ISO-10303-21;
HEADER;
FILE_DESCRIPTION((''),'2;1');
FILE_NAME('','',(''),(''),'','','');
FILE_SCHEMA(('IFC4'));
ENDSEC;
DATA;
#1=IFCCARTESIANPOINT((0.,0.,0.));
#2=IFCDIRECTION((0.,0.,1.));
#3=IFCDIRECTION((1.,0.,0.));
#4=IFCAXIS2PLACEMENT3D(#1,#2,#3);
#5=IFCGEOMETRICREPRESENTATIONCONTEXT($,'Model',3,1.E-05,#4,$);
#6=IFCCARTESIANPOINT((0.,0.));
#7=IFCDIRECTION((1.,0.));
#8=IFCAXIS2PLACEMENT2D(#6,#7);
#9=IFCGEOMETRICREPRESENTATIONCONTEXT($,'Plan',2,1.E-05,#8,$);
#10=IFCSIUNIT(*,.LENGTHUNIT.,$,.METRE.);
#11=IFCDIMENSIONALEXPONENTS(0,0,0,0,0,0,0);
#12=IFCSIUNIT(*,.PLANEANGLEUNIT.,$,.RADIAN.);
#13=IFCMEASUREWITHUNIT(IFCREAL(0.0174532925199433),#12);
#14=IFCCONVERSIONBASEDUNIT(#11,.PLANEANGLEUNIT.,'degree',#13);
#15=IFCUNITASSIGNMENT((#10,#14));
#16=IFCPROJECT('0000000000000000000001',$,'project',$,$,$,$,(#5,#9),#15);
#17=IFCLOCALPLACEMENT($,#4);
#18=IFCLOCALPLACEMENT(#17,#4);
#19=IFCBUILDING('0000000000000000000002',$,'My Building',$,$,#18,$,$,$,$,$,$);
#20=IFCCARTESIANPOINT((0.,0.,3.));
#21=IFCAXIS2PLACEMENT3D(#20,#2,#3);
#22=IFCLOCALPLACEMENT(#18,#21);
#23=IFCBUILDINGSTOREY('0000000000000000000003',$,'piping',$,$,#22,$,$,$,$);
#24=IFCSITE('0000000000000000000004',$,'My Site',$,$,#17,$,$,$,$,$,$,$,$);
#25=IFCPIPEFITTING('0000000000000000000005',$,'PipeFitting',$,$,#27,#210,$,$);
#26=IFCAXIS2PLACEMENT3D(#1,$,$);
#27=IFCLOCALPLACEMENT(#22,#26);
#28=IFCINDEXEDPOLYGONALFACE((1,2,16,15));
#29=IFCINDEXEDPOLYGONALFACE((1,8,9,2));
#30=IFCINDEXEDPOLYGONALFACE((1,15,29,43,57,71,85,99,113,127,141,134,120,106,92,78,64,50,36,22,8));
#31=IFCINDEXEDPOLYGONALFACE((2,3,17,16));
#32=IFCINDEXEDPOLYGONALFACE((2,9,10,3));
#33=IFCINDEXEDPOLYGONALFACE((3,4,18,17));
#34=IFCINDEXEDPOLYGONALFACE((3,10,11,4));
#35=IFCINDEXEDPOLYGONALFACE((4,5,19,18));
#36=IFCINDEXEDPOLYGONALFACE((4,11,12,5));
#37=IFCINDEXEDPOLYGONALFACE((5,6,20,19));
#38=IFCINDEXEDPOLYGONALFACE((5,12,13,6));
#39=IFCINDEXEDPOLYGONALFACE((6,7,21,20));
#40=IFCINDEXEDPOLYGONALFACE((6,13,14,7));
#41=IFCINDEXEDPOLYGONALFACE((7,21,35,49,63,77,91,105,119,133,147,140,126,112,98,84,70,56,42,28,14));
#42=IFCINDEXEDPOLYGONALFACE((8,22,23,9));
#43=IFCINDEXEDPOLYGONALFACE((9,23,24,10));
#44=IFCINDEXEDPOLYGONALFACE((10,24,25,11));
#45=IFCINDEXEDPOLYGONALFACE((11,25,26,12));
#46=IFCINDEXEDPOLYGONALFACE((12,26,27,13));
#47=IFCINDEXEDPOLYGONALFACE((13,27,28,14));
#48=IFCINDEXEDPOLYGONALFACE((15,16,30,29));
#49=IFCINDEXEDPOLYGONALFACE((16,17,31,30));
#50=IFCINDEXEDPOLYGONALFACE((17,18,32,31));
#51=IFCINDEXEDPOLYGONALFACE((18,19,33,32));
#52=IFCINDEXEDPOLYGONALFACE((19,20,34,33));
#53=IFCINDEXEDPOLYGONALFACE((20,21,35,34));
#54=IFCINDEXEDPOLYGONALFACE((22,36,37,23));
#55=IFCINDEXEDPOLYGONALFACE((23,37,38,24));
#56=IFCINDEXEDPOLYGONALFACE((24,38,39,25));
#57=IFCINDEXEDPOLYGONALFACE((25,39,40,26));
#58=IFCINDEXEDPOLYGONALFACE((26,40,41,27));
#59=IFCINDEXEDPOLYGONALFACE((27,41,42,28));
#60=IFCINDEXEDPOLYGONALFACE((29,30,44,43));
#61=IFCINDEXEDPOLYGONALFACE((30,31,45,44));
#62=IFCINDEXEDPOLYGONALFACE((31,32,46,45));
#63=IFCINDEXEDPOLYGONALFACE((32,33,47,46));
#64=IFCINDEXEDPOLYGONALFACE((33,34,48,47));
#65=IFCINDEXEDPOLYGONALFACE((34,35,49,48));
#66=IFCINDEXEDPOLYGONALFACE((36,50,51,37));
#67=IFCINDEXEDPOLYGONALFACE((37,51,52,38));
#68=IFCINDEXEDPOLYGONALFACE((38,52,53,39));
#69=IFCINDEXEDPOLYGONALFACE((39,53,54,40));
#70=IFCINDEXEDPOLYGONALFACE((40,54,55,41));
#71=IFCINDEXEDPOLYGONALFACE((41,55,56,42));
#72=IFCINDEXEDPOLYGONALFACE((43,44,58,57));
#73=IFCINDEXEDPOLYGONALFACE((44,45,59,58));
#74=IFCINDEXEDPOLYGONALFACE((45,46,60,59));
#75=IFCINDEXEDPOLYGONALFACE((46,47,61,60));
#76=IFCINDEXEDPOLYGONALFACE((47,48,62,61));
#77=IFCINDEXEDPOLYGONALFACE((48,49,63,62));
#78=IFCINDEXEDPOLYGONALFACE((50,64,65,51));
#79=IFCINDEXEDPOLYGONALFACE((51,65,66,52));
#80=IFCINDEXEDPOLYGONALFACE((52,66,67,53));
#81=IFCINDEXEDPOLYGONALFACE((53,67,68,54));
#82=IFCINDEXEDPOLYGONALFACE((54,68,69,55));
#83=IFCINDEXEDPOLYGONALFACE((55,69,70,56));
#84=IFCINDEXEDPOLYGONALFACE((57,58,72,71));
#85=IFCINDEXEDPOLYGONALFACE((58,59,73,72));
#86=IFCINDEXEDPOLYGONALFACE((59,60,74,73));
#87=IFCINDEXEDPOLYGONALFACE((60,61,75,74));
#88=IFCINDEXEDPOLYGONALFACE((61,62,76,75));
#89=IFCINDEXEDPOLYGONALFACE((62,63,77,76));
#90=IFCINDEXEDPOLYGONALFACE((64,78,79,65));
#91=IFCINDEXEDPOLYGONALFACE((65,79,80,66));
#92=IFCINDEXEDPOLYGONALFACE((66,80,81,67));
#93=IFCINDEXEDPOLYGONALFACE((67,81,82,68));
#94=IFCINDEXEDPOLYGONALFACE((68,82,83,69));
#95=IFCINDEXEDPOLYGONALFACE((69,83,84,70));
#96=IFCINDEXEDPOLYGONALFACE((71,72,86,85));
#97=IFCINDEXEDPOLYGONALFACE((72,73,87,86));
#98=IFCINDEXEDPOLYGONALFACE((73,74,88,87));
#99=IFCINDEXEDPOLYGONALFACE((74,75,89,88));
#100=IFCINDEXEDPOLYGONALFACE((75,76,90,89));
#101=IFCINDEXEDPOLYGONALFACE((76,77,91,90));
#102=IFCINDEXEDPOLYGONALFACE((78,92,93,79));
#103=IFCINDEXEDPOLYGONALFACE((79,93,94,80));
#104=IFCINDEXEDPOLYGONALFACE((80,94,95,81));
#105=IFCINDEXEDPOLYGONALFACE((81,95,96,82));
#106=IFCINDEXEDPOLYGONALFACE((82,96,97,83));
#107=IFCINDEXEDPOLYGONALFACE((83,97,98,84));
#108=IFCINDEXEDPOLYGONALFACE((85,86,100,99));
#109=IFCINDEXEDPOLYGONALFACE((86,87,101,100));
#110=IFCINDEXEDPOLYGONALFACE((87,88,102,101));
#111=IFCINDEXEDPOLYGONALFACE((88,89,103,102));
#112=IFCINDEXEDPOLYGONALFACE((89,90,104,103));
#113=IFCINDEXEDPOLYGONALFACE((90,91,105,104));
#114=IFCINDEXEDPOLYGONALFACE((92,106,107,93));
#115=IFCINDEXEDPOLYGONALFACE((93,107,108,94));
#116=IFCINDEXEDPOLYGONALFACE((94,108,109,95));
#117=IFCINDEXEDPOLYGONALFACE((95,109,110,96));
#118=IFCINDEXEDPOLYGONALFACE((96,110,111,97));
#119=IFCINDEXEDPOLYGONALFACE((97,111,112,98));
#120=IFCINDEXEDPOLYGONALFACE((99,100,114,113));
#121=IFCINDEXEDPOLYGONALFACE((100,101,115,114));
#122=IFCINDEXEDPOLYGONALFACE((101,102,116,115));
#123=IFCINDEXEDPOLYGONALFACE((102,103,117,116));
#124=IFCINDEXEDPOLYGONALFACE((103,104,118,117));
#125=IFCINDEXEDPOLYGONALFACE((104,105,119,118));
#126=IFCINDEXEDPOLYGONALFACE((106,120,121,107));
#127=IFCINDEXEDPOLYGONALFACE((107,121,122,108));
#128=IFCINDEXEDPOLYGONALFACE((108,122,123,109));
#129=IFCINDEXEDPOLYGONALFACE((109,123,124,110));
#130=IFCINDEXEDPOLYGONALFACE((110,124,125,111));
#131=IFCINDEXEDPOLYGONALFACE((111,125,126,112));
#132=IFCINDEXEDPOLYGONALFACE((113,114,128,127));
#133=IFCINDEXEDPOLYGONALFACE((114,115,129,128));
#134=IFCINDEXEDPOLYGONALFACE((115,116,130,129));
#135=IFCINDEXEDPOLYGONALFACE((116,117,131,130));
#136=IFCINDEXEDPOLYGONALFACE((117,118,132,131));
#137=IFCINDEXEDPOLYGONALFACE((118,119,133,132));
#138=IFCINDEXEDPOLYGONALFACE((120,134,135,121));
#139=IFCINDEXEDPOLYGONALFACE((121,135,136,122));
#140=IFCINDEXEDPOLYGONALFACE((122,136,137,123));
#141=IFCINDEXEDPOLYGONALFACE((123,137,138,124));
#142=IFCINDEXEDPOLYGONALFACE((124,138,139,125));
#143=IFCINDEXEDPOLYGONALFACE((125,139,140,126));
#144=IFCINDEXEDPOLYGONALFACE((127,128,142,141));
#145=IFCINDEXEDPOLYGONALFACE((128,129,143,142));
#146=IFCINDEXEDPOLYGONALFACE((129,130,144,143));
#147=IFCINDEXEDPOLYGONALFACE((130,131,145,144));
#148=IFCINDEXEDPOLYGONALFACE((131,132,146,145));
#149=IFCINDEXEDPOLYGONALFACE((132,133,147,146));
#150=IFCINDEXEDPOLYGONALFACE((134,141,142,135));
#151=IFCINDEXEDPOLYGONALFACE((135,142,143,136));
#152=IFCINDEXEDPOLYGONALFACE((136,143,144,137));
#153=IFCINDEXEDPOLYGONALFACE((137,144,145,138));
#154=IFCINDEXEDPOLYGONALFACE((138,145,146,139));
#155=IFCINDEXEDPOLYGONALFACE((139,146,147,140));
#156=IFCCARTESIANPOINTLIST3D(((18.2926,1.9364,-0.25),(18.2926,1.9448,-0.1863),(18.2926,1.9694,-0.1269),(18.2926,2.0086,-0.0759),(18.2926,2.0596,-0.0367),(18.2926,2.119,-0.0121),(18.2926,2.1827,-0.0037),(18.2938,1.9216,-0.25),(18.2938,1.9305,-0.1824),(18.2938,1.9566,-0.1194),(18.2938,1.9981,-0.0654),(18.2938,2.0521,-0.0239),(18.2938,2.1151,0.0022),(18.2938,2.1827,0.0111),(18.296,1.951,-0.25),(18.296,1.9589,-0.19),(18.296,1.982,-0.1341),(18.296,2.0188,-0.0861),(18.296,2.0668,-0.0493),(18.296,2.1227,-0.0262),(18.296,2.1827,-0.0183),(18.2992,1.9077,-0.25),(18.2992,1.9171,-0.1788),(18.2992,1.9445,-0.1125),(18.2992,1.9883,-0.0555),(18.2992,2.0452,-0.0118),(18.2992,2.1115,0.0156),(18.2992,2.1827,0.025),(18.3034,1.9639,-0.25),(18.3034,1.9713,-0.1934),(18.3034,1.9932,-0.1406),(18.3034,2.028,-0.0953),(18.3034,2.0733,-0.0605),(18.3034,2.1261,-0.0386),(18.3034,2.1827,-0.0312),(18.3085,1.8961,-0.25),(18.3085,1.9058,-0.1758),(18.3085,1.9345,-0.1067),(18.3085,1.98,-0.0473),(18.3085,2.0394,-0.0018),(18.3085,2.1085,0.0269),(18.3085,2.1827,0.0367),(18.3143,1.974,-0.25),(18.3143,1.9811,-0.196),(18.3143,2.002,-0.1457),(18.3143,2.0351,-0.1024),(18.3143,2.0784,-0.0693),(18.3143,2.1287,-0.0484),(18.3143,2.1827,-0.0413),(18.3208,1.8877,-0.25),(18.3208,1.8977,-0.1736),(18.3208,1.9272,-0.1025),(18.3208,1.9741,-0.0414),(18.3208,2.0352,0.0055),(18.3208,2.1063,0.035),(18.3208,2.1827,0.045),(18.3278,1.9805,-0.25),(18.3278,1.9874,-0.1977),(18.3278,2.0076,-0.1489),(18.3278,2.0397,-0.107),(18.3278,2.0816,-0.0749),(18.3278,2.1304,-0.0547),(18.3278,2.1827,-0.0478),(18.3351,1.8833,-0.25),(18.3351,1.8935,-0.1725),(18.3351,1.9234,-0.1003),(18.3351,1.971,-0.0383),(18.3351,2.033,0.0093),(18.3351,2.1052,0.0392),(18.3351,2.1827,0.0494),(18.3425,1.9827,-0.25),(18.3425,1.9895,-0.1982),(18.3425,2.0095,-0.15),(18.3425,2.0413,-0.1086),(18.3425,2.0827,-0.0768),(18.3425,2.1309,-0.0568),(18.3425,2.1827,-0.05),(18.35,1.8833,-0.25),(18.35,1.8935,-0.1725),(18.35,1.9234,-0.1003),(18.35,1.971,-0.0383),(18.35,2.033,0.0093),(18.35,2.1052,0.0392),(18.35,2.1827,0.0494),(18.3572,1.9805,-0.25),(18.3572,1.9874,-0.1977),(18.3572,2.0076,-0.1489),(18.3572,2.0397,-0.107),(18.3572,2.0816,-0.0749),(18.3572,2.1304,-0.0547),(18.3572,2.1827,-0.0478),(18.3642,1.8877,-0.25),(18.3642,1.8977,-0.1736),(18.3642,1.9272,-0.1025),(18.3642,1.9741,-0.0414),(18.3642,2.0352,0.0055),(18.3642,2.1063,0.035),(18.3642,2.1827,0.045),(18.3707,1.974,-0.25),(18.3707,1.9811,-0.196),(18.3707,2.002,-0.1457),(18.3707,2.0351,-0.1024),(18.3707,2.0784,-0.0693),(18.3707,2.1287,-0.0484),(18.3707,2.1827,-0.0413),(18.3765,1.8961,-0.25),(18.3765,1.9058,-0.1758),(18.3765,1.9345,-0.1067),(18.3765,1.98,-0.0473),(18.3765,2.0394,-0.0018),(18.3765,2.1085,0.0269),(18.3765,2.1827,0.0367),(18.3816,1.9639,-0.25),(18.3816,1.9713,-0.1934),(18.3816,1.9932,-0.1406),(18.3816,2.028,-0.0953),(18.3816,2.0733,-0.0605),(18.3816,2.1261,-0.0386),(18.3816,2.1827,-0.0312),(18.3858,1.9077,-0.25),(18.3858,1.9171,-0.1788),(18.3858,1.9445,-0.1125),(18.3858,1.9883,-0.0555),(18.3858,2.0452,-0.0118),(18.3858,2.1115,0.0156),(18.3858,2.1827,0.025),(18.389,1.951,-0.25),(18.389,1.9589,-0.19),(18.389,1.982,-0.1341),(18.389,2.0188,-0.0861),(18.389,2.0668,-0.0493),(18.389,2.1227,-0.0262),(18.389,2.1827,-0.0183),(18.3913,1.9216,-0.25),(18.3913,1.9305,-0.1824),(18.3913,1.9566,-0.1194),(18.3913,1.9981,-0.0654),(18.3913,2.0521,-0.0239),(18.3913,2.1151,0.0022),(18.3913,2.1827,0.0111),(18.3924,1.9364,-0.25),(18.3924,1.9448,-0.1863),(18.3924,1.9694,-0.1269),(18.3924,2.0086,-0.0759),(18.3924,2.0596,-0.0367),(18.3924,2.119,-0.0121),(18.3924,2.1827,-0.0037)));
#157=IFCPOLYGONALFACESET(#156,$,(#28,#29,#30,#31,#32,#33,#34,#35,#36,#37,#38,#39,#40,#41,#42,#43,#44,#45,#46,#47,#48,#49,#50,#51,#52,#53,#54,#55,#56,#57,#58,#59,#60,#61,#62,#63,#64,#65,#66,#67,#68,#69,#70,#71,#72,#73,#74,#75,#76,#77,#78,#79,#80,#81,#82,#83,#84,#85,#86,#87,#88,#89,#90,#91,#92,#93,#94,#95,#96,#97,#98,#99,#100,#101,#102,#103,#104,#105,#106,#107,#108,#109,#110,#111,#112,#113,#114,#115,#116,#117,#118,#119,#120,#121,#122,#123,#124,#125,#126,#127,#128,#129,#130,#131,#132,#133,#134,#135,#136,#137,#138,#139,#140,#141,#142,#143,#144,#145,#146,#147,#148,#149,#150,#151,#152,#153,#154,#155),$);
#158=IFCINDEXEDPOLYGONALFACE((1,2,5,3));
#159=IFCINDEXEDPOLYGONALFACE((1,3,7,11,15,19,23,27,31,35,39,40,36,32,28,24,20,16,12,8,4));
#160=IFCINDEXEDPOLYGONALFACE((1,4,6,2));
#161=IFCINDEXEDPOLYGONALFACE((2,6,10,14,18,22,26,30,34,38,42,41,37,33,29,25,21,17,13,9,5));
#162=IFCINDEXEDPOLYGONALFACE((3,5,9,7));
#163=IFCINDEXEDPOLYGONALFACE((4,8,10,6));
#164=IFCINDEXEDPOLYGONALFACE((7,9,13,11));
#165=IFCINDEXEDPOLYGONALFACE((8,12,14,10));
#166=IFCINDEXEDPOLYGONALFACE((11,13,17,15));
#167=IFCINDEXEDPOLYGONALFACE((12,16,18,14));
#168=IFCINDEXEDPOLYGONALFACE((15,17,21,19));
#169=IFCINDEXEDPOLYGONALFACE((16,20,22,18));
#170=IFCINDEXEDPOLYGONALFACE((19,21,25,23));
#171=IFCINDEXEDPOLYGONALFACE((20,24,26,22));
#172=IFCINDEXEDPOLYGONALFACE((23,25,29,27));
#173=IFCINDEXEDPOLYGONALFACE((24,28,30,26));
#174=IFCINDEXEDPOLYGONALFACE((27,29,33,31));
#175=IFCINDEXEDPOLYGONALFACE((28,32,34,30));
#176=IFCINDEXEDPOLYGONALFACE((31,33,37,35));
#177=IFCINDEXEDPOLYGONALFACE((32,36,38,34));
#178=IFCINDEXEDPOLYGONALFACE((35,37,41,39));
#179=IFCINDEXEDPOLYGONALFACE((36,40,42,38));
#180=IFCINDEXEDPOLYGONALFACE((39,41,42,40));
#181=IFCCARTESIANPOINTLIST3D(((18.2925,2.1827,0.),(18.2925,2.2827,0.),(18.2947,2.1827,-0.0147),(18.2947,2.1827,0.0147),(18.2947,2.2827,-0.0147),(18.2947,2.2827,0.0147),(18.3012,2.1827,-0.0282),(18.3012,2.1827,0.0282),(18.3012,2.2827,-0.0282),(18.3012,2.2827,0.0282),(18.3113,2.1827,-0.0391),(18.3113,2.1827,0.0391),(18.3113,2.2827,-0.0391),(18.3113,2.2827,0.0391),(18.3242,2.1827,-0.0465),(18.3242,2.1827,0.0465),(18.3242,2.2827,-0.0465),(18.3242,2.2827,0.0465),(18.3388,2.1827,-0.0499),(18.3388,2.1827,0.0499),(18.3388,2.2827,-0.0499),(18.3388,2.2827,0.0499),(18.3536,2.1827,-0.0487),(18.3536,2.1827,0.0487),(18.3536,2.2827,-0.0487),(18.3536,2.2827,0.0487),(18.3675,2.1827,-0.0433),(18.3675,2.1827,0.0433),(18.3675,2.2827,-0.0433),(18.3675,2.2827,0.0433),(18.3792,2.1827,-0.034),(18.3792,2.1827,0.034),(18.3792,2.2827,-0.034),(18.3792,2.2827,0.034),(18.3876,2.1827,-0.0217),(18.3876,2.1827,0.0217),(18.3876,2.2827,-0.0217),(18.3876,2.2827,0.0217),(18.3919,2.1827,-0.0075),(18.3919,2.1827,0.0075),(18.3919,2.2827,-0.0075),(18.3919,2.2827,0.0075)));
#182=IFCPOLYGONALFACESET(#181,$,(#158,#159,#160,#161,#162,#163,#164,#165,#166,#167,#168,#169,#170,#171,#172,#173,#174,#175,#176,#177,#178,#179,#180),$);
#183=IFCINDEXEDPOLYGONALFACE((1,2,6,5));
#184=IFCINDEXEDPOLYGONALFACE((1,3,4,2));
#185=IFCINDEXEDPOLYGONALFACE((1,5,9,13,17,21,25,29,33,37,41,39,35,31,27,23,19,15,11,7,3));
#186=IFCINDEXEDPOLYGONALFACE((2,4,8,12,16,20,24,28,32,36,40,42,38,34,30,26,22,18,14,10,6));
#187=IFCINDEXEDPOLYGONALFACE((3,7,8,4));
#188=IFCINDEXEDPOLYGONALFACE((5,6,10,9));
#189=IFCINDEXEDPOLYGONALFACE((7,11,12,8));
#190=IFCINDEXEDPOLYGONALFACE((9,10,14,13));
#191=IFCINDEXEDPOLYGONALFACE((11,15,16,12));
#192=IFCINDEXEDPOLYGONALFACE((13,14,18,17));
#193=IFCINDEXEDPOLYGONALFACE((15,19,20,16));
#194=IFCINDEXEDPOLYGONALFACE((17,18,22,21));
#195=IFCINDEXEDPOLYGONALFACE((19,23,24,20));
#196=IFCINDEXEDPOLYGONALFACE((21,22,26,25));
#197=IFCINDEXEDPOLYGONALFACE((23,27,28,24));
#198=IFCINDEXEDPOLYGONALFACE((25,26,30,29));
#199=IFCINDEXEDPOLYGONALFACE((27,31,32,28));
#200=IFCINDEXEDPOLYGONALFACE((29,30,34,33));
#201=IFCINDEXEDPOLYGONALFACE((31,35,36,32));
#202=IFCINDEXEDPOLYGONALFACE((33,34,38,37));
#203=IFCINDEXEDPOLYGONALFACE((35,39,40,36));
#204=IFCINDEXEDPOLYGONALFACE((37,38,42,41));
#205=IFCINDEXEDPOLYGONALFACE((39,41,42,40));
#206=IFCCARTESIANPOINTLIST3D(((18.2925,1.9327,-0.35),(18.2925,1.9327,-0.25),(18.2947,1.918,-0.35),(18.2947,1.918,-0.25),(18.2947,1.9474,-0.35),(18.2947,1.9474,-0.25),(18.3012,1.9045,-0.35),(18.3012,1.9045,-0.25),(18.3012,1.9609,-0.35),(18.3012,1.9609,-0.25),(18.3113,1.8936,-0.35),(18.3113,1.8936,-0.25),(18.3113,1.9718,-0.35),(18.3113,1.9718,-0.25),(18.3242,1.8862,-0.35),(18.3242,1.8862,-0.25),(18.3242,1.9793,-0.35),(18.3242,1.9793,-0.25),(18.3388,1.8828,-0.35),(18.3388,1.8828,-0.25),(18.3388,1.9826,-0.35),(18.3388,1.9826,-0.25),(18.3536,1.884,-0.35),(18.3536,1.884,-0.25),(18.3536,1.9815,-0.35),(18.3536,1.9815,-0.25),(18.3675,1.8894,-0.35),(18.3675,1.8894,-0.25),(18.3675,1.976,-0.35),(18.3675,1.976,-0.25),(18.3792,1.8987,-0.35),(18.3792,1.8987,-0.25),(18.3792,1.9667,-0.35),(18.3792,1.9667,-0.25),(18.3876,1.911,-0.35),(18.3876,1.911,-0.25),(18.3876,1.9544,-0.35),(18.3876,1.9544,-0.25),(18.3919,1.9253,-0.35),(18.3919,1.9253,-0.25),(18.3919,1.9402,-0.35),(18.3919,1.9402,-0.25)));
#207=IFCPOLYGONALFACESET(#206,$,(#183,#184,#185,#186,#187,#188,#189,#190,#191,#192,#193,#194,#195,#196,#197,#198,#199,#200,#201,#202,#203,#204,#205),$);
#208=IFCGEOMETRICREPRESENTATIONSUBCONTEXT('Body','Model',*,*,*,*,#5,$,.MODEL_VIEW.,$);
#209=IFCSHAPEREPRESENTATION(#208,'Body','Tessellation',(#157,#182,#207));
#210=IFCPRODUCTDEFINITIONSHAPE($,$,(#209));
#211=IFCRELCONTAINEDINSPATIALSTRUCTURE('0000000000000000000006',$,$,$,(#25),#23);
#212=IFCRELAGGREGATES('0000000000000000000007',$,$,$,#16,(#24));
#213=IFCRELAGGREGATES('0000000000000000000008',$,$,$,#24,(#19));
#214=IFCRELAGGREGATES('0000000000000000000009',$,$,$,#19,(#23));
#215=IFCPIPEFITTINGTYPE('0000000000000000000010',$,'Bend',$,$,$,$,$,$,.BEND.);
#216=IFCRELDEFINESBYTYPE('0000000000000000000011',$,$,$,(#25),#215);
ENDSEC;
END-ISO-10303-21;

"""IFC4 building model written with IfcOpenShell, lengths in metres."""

from ifc_helpers import new_model, entity, si_unit, converted_unit, frame, origin_with_axes, origin_2d_with_axis, place, context, subcontext, project, spatial, circle, extrude, source, transform, mapped, type_object, type_shapes, element, save


model = new_model("IFC4")

# Units and contexts
model_context = context("Model", 3, precision=1e-05, world=origin_with_axes())
plan_context = context("Plan", 2, precision=1e-05, world=origin_2d_with_axis())
body_context = subcontext(model_context, "Body", "Model", "MODEL_VIEW")
ifc_project = project(units=[si_unit("LENGTHUNIT", "METRE"), converted_unit("PLANEANGLEUNIT", "degree", entity("IfcReal", 0.0174532925199433), si_unit("PLANEANGLEUNIT", "RADIAN"), dimensions=[0, 0, 0, 0, 0, 0, 0])], contexts=[model_context, plan_context])

# Site, building, storey
site_placement = place(None, origin_with_axes())
site = spatial("IfcSite", under=ifc_project, at=site_placement, Name="My Site")
building_placement = place(site_placement, origin_with_axes())
building = spatial("IfcBuilding", under=site, at=building_placement, Name="My Building")
storey_placement = place(building_placement, frame((0.0, 0.0, 3.0), z_axis=(0.0, 0.0, 1.0), x_axis=(1.0, 0.0, 0.0)))
storey = spatial("IfcBuildingStorey", under=building, at=storey_placement, Name="piping")

# Pipe fitting
pipe_fitting_type = type_object("IfcPipeFittingType", Name="Bend", PredefinedType="BEND")
shared_shape = source(origin_with_axes(), body_context, "Body", "SolidModel", [
    entity("IfcSweptDiskSolid", entity("IfcIndexedPolyCurve", entity("IfcCartesianPointList3D", [[0.0, 0.0, -0.1], [0.0, -0.0732, -0.2768], [0.0, -0.25, -0.35]]), [entity("IfcArcIndex", [1, 2, 3])]), 0.05),
    extrude(circle(Radius=0.05), origin_with_axes(), (0.0, 0.0, -1.0), 0.1),
    extrude(circle(Radius=0.05), frame((0.0, -0.25, -0.35), z_axis=(0.0, -1.0, 0.0), x_axis=(1.0, 0.0, 0.0)), (0.0, 0.0, 1.0), 0.1),
])
type_shapes(pipe_fitting_type, [shared_shape])
for number, where, z_axis, x_axis, name in (
    (1, (18.3425, 2.2827, 0.0), (0.0, 1.0, 0.0), (-1.0, 0.0, 0.0), "PipeFitting"),
):
    element("IfcPipeFitting", number, at=place(storey_placement, frame(where, z_axis=z_axis, x_axis=x_axis)), inside=storey, type_object=pipe_fitting_type, Name=name, context=body_context, shape_type="MappedRepresentation", body=[
        mapped(shared_shape, transform((0.0, 0.0, 0.0), x_axis=(1.0, 0.0, 0.0), y_axis=(0.0, 1.0, 0.0), z_axis=(0.0, 0.0, 1.0), scale=1.0)),
    ])

save(model, "model.ifc")
